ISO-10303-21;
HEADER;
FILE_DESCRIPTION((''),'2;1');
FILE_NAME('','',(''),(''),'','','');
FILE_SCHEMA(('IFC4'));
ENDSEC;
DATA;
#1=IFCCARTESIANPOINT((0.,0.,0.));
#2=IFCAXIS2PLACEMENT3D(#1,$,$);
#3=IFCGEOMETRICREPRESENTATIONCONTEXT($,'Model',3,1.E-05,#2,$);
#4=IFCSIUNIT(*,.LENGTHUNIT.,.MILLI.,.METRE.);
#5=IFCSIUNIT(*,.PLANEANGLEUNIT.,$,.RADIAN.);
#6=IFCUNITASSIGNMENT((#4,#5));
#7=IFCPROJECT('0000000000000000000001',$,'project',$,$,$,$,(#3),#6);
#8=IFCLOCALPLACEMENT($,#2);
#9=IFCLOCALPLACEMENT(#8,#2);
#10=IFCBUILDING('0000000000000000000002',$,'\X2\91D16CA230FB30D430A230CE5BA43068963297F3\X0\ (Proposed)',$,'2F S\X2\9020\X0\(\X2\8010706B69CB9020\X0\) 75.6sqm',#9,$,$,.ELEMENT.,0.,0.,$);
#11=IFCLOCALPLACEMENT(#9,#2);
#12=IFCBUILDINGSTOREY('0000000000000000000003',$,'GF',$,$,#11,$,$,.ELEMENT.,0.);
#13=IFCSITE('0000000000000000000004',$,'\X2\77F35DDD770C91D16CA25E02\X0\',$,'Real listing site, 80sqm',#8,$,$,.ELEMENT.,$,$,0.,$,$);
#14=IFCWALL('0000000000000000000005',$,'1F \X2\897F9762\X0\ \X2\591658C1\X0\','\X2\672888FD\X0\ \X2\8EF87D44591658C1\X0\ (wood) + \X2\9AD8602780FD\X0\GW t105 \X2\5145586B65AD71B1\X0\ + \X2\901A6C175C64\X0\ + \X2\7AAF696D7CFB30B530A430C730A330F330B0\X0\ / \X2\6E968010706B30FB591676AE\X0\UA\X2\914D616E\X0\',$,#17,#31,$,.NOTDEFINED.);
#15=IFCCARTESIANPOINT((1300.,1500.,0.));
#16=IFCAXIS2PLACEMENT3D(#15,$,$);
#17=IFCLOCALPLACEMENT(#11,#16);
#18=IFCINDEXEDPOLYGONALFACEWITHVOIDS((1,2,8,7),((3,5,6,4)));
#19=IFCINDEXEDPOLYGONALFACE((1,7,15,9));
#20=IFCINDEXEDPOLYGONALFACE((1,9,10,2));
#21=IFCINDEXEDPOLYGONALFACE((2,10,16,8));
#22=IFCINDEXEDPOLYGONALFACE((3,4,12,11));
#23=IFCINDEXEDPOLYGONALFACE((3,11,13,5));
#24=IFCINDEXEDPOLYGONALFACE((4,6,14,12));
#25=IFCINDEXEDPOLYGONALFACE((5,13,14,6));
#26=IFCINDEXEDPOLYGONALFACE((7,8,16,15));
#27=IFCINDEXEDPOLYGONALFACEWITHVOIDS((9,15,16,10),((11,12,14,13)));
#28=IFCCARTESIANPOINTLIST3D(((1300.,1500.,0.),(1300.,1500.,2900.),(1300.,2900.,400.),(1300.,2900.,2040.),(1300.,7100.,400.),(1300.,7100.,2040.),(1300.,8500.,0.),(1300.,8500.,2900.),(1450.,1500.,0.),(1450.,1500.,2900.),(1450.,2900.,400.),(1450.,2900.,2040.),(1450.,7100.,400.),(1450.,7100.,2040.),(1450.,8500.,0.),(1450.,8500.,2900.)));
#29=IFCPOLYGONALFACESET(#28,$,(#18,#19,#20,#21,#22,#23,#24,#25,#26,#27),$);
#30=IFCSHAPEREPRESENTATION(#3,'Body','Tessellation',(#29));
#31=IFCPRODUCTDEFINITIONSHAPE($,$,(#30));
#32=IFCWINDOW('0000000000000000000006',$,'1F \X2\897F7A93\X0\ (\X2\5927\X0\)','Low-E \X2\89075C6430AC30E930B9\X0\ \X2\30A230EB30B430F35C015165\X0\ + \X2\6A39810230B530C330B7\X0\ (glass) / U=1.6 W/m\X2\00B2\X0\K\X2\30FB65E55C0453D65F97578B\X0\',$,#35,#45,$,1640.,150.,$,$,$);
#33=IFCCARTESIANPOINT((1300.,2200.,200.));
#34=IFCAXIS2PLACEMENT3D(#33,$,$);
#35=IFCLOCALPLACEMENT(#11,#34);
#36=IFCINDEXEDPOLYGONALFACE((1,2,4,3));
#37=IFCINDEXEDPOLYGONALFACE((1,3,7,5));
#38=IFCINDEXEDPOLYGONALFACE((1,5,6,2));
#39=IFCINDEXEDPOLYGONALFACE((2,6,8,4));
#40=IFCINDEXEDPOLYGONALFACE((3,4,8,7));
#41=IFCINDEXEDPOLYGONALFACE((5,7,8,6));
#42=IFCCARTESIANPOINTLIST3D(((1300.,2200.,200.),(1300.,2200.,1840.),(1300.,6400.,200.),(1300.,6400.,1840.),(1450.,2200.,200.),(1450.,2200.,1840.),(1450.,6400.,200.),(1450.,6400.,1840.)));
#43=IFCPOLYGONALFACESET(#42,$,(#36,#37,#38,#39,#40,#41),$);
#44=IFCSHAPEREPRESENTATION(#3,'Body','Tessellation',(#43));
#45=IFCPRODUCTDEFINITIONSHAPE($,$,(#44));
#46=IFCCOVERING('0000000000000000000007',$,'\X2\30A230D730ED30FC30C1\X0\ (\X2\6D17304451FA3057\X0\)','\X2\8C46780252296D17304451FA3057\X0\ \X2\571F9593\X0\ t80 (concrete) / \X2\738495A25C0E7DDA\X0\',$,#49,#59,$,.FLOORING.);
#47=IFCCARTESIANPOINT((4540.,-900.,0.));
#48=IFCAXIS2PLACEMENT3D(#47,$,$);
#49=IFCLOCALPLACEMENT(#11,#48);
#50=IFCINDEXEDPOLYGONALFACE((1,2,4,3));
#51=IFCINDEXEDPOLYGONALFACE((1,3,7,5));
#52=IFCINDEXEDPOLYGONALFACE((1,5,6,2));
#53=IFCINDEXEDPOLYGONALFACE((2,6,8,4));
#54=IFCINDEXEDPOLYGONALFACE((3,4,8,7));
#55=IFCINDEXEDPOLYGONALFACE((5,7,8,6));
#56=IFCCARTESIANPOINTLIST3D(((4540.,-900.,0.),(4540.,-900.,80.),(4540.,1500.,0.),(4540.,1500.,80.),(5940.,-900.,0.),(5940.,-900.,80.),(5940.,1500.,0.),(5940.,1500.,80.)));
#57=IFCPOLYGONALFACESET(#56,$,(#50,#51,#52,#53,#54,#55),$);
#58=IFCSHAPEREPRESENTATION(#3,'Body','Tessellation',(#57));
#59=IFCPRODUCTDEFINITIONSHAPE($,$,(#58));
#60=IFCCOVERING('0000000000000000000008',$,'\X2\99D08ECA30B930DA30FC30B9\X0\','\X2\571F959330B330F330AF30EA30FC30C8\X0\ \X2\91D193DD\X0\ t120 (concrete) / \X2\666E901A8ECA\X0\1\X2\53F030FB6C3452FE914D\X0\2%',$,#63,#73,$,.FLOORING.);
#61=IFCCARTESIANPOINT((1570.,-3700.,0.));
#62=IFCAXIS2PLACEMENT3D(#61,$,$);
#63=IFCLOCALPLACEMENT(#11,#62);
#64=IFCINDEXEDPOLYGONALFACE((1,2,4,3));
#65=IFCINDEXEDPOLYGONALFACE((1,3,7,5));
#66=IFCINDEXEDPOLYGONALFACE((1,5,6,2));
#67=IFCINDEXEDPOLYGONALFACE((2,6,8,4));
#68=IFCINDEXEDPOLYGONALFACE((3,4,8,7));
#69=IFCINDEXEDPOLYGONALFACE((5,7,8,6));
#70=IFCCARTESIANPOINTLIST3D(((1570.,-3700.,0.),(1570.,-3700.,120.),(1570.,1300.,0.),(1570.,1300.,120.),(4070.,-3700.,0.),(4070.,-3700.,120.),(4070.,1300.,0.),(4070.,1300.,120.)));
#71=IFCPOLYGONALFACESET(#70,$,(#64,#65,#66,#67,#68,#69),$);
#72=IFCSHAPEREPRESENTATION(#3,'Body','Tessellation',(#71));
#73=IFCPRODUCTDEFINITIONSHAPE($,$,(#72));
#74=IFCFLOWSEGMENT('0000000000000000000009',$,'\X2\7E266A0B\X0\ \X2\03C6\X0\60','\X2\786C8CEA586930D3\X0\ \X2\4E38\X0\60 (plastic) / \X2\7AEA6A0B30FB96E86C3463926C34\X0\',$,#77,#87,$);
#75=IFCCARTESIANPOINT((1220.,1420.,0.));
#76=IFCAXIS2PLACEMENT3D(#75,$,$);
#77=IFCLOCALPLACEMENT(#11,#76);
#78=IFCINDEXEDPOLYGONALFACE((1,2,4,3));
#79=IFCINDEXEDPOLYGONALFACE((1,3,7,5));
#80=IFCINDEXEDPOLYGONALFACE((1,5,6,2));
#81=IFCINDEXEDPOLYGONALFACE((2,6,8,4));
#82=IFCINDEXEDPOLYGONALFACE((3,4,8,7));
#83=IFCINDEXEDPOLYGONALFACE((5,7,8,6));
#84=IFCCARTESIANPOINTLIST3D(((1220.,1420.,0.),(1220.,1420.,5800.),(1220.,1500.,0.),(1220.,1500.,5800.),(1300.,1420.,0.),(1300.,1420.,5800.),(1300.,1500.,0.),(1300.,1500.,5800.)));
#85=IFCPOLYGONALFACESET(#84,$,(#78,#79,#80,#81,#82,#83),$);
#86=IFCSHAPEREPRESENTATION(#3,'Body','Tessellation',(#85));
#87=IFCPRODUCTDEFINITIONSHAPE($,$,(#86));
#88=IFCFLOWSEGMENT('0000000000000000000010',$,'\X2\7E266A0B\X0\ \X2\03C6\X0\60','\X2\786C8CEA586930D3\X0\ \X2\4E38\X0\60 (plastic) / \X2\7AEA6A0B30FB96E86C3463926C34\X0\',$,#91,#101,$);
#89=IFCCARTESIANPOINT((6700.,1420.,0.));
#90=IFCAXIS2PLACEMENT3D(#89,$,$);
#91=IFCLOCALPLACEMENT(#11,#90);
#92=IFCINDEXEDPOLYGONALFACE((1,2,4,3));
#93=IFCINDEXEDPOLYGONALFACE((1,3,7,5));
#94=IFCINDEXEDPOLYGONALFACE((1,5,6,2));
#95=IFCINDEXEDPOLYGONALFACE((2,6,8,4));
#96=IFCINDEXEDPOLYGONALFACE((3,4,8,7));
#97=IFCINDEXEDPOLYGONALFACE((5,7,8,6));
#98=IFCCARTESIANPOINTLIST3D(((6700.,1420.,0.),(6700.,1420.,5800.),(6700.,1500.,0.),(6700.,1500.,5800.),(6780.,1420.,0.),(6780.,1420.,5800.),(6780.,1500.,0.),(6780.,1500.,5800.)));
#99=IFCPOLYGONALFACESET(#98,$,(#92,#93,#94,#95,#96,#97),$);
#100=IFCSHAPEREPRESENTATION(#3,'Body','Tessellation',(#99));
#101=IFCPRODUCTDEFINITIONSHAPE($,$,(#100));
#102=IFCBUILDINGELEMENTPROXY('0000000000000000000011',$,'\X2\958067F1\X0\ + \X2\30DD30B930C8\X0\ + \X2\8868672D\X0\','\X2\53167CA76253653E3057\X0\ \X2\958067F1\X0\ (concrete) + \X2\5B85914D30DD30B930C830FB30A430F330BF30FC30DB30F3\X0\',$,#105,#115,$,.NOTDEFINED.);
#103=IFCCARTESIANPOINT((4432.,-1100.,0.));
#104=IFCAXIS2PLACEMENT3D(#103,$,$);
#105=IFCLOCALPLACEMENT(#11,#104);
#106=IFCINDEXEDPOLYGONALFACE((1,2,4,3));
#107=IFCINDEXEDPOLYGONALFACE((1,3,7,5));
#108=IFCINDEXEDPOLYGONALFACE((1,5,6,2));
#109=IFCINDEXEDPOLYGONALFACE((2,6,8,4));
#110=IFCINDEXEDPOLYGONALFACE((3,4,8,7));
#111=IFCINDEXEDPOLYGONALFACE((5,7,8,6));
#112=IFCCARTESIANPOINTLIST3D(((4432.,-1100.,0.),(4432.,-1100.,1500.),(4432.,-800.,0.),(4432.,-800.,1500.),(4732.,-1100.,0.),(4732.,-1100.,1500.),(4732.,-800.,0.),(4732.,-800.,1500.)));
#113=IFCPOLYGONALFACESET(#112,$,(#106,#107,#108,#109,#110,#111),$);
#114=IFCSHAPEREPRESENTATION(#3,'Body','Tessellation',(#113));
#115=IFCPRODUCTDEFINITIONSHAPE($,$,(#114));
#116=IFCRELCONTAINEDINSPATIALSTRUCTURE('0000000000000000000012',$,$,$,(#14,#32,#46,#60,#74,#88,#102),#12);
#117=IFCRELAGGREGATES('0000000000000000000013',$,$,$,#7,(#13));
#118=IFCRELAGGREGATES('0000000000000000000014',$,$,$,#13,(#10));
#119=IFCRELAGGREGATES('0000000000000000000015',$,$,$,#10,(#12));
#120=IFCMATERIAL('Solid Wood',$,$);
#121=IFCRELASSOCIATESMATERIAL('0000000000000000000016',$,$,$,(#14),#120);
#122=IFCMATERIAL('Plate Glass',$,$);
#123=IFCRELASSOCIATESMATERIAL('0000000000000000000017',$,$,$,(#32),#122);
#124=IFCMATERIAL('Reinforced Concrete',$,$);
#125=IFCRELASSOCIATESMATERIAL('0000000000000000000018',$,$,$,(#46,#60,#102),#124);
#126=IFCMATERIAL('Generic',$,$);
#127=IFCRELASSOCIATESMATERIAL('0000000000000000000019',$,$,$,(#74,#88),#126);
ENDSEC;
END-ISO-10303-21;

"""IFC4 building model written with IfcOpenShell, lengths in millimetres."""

from ifc_helpers import new_model, si_unit, frame, frame_2d, origin, place, context, project, spatial, rectangle, extrude, material, element, fill, save


model = new_model("IFC4")

# Units and contexts
model_context = context("Model", 3, precision=1e-05, world=origin())
ifc_project = project(units=[si_unit("LENGTHUNIT", "METRE", prefix="MILLI"), si_unit("PLANEANGLEUNIT", "RADIAN")], contexts=[model_context])

# Site, building, storey
site_placement = place(None, origin())
site = spatial("IfcSite", under=ifc_project, at=site_placement, Name="石川県金沢市", ObjectType="Real listing site, 80sqm", CompositionType="ELEMENT", RefElevation=0.0)
building_placement = place(site_placement, origin())
building = spatial("IfcBuilding", under=site, at=building_placement, Name="金沢・ピアノ室と防音 (Proposed)", ObjectType="2F S造(耐火構造) 75.6sqm", CompositionType="ELEMENT", ElevationOfRefHeight=0.0, ElevationOfTerrain=0.0)
storey_placement = place(building_placement, origin())
storey = spatial("IfcBuildingStorey", under=building, at=storey_placement, Name="GF", CompositionType="ELEMENT", Elevation=0.0)

# Shared definitions
ifc_material_1 = material(Name="Solid Wood")

# Shared definitions
ifc_material_2 = material(Name="Reinforced Concrete")

# Shared definitions
ifc_material_3 = material(Name="Plate Glass")

# Wall, opening, window
wall_1_placement = place(storey_placement, frame((1300.0, 1500.0, 0.0)))
wall_1 = element("IfcWall", 1, at=wall_1_placement, inside=storey, material=ifc_material_1, Name="1F 西面 外壁", Description="木製 軸組外壁 (wood) + 高性能GW t105 充填断熱 + 通気層 + 窯業系サイディング / 準耐火・外皮UA配慮", PredefinedType="NOTDEFINED", context=model_context, shape_type="SweptSolid", body=[
    extrude(rectangle(XDim=150.0, YDim=7000.0, at=frame_2d((75.0, 3500.0))), frame((1300.0, 1500.0, 0.0)), (0.0, 0.0, 1.0), 2900.0),
])
opening_1_placement = place(storey_placement, frame((1300.0, 2200.0, 200.0)))
opening_1 = element("IfcOpeningElement", 2, at=opening_1_placement, cuts=wall_1, PredefinedType="NOTDEFINED", context=model_context, shape_type="SweptSolid", body=[
    extrude(rectangle(XDim=150.0, YDim=4200.0, at=frame_2d((75.0, 2100.0))), frame((1300.0, 2200.0, 200.0)), (0.0, 0.0, 1.0), 1640.0),
])
window_1_placement = place(storey_placement, frame((1300.0, 2200.0, 200.0)))
window_1 = element("IfcWindow", 3, at=window_1_placement, inside=storey, material=ifc_material_3, Name="1F 西窓 (大)", Description="Low-E 複層ガラス アルゴン封入 + 樹脂サッシ (glass) / U=1.6 W/m²K・日射取得型", OverallHeight=1640.0, OverallWidth=150.0, context=model_context, shape_type="SweptSolid", body=[
    extrude(rectangle(XDim=150.0, YDim=4200.0, at=frame_2d((75.0, 2100.0))), frame((1300.0, 2200.0, 200.0)), (0.0, 0.0, 1.0), 1640.0),
])
fill(opening_1, window_1)

# Coverings
covering_1_placement = place(storey_placement, frame((4540.0, -900.0, 0.0)))
element("IfcCovering", 4, at=covering_1_placement, inside=storey, material=ifc_material_2, Name="アプローチ (洗い出し)", Description="豆砂利洗い出し 土間 t80 (concrete) / 玄関導線", PredefinedType="FLOORING", context=model_context, shape_type="SweptSolid", body=[
    extrude(rectangle(XDim=1400.0, YDim=2400.0, at=frame_2d((700.0, 1200.0))), frame((4540.0, -900.0, 0.0)), (0.0, 0.0, 1.0), 80.0),
])
covering_2_placement = place(storey_placement, frame((1570.0, -3700.0, 0.0)))
element("IfcCovering", 5, at=covering_2_placement, inside=storey, material=ifc_material_2, Name="駐車スペース", Description="土間コンクリート 金鏝 t120 (concrete) / 普通車1台・水勾配2%", PredefinedType="FLOORING", context=model_context, shape_type="SweptSolid", body=[
    extrude(rectangle(XDim=2500.0, YDim=5000.0, at=frame_2d((1250.0, 2500.0))), frame((1570.0, -3700.0, 0.0)), (0.0, 0.0, 1.0), 120.0),
])

# Flow segments
ifc_material_4 = material(Name="Generic")
flow_segment_1_placement = place(storey_placement, frame((1220.0, 1420.0, 0.0)))
element("IfcFlowSegment", 6, at=flow_segment_1_placement, inside=storey, material=ifc_material_4, Name="縦樋 φ60", Description="硬質塩ビ 丸60 (plastic) / 竪樋・雨水排水", context=model_context, shape_type="SweptSolid", body=[
    extrude(rectangle(XDim=80.0, YDim=80.0, at=frame_2d((40.0, 40.0))), frame((1220.0, 1420.0, 0.0)), (0.0, 0.0, 1.0), 5800.0),
])
flow_segment_2_placement = place(storey_placement, frame((6700.0, 1420.0, 0.0)))
element("IfcFlowSegment", 7, at=flow_segment_2_placement, inside=storey, material=ifc_material_4, Name="縦樋 φ60", Description="硬質塩ビ 丸60 (plastic) / 竪樋・雨水排水", context=model_context, shape_type="SweptSolid", body=[
    extrude(rectangle(XDim=80.0, YDim=80.0, at=frame_2d((40.0, 40.0))), frame((6700.0, 1420.0, 0.0)), (0.0, 0.0, 1.0), 5800.0),
])

# Building element proxy
proxy_placement = place(storey_placement, frame((4432.0, -1100.0, 0.0)))
element("IfcBuildingElementProxy", 8, at=proxy_placement, inside=storey, material=ifc_material_2, Name="門柱 + ポスト + 表札", Description="化粧打放し 門柱 (concrete) + 宅配ポスト・インターホン", PredefinedType="NOTDEFINED", context=model_context, shape_type="SweptSolid", body=[
    extrude(rectangle(XDim=300.0, YDim=300.0, at=frame_2d((150.0, 150.0))), frame((4432.0, -1100.0, 0.0)), (0.0, 0.0, 1.0), 1500.0),
])

save(model, "model.ifc")
